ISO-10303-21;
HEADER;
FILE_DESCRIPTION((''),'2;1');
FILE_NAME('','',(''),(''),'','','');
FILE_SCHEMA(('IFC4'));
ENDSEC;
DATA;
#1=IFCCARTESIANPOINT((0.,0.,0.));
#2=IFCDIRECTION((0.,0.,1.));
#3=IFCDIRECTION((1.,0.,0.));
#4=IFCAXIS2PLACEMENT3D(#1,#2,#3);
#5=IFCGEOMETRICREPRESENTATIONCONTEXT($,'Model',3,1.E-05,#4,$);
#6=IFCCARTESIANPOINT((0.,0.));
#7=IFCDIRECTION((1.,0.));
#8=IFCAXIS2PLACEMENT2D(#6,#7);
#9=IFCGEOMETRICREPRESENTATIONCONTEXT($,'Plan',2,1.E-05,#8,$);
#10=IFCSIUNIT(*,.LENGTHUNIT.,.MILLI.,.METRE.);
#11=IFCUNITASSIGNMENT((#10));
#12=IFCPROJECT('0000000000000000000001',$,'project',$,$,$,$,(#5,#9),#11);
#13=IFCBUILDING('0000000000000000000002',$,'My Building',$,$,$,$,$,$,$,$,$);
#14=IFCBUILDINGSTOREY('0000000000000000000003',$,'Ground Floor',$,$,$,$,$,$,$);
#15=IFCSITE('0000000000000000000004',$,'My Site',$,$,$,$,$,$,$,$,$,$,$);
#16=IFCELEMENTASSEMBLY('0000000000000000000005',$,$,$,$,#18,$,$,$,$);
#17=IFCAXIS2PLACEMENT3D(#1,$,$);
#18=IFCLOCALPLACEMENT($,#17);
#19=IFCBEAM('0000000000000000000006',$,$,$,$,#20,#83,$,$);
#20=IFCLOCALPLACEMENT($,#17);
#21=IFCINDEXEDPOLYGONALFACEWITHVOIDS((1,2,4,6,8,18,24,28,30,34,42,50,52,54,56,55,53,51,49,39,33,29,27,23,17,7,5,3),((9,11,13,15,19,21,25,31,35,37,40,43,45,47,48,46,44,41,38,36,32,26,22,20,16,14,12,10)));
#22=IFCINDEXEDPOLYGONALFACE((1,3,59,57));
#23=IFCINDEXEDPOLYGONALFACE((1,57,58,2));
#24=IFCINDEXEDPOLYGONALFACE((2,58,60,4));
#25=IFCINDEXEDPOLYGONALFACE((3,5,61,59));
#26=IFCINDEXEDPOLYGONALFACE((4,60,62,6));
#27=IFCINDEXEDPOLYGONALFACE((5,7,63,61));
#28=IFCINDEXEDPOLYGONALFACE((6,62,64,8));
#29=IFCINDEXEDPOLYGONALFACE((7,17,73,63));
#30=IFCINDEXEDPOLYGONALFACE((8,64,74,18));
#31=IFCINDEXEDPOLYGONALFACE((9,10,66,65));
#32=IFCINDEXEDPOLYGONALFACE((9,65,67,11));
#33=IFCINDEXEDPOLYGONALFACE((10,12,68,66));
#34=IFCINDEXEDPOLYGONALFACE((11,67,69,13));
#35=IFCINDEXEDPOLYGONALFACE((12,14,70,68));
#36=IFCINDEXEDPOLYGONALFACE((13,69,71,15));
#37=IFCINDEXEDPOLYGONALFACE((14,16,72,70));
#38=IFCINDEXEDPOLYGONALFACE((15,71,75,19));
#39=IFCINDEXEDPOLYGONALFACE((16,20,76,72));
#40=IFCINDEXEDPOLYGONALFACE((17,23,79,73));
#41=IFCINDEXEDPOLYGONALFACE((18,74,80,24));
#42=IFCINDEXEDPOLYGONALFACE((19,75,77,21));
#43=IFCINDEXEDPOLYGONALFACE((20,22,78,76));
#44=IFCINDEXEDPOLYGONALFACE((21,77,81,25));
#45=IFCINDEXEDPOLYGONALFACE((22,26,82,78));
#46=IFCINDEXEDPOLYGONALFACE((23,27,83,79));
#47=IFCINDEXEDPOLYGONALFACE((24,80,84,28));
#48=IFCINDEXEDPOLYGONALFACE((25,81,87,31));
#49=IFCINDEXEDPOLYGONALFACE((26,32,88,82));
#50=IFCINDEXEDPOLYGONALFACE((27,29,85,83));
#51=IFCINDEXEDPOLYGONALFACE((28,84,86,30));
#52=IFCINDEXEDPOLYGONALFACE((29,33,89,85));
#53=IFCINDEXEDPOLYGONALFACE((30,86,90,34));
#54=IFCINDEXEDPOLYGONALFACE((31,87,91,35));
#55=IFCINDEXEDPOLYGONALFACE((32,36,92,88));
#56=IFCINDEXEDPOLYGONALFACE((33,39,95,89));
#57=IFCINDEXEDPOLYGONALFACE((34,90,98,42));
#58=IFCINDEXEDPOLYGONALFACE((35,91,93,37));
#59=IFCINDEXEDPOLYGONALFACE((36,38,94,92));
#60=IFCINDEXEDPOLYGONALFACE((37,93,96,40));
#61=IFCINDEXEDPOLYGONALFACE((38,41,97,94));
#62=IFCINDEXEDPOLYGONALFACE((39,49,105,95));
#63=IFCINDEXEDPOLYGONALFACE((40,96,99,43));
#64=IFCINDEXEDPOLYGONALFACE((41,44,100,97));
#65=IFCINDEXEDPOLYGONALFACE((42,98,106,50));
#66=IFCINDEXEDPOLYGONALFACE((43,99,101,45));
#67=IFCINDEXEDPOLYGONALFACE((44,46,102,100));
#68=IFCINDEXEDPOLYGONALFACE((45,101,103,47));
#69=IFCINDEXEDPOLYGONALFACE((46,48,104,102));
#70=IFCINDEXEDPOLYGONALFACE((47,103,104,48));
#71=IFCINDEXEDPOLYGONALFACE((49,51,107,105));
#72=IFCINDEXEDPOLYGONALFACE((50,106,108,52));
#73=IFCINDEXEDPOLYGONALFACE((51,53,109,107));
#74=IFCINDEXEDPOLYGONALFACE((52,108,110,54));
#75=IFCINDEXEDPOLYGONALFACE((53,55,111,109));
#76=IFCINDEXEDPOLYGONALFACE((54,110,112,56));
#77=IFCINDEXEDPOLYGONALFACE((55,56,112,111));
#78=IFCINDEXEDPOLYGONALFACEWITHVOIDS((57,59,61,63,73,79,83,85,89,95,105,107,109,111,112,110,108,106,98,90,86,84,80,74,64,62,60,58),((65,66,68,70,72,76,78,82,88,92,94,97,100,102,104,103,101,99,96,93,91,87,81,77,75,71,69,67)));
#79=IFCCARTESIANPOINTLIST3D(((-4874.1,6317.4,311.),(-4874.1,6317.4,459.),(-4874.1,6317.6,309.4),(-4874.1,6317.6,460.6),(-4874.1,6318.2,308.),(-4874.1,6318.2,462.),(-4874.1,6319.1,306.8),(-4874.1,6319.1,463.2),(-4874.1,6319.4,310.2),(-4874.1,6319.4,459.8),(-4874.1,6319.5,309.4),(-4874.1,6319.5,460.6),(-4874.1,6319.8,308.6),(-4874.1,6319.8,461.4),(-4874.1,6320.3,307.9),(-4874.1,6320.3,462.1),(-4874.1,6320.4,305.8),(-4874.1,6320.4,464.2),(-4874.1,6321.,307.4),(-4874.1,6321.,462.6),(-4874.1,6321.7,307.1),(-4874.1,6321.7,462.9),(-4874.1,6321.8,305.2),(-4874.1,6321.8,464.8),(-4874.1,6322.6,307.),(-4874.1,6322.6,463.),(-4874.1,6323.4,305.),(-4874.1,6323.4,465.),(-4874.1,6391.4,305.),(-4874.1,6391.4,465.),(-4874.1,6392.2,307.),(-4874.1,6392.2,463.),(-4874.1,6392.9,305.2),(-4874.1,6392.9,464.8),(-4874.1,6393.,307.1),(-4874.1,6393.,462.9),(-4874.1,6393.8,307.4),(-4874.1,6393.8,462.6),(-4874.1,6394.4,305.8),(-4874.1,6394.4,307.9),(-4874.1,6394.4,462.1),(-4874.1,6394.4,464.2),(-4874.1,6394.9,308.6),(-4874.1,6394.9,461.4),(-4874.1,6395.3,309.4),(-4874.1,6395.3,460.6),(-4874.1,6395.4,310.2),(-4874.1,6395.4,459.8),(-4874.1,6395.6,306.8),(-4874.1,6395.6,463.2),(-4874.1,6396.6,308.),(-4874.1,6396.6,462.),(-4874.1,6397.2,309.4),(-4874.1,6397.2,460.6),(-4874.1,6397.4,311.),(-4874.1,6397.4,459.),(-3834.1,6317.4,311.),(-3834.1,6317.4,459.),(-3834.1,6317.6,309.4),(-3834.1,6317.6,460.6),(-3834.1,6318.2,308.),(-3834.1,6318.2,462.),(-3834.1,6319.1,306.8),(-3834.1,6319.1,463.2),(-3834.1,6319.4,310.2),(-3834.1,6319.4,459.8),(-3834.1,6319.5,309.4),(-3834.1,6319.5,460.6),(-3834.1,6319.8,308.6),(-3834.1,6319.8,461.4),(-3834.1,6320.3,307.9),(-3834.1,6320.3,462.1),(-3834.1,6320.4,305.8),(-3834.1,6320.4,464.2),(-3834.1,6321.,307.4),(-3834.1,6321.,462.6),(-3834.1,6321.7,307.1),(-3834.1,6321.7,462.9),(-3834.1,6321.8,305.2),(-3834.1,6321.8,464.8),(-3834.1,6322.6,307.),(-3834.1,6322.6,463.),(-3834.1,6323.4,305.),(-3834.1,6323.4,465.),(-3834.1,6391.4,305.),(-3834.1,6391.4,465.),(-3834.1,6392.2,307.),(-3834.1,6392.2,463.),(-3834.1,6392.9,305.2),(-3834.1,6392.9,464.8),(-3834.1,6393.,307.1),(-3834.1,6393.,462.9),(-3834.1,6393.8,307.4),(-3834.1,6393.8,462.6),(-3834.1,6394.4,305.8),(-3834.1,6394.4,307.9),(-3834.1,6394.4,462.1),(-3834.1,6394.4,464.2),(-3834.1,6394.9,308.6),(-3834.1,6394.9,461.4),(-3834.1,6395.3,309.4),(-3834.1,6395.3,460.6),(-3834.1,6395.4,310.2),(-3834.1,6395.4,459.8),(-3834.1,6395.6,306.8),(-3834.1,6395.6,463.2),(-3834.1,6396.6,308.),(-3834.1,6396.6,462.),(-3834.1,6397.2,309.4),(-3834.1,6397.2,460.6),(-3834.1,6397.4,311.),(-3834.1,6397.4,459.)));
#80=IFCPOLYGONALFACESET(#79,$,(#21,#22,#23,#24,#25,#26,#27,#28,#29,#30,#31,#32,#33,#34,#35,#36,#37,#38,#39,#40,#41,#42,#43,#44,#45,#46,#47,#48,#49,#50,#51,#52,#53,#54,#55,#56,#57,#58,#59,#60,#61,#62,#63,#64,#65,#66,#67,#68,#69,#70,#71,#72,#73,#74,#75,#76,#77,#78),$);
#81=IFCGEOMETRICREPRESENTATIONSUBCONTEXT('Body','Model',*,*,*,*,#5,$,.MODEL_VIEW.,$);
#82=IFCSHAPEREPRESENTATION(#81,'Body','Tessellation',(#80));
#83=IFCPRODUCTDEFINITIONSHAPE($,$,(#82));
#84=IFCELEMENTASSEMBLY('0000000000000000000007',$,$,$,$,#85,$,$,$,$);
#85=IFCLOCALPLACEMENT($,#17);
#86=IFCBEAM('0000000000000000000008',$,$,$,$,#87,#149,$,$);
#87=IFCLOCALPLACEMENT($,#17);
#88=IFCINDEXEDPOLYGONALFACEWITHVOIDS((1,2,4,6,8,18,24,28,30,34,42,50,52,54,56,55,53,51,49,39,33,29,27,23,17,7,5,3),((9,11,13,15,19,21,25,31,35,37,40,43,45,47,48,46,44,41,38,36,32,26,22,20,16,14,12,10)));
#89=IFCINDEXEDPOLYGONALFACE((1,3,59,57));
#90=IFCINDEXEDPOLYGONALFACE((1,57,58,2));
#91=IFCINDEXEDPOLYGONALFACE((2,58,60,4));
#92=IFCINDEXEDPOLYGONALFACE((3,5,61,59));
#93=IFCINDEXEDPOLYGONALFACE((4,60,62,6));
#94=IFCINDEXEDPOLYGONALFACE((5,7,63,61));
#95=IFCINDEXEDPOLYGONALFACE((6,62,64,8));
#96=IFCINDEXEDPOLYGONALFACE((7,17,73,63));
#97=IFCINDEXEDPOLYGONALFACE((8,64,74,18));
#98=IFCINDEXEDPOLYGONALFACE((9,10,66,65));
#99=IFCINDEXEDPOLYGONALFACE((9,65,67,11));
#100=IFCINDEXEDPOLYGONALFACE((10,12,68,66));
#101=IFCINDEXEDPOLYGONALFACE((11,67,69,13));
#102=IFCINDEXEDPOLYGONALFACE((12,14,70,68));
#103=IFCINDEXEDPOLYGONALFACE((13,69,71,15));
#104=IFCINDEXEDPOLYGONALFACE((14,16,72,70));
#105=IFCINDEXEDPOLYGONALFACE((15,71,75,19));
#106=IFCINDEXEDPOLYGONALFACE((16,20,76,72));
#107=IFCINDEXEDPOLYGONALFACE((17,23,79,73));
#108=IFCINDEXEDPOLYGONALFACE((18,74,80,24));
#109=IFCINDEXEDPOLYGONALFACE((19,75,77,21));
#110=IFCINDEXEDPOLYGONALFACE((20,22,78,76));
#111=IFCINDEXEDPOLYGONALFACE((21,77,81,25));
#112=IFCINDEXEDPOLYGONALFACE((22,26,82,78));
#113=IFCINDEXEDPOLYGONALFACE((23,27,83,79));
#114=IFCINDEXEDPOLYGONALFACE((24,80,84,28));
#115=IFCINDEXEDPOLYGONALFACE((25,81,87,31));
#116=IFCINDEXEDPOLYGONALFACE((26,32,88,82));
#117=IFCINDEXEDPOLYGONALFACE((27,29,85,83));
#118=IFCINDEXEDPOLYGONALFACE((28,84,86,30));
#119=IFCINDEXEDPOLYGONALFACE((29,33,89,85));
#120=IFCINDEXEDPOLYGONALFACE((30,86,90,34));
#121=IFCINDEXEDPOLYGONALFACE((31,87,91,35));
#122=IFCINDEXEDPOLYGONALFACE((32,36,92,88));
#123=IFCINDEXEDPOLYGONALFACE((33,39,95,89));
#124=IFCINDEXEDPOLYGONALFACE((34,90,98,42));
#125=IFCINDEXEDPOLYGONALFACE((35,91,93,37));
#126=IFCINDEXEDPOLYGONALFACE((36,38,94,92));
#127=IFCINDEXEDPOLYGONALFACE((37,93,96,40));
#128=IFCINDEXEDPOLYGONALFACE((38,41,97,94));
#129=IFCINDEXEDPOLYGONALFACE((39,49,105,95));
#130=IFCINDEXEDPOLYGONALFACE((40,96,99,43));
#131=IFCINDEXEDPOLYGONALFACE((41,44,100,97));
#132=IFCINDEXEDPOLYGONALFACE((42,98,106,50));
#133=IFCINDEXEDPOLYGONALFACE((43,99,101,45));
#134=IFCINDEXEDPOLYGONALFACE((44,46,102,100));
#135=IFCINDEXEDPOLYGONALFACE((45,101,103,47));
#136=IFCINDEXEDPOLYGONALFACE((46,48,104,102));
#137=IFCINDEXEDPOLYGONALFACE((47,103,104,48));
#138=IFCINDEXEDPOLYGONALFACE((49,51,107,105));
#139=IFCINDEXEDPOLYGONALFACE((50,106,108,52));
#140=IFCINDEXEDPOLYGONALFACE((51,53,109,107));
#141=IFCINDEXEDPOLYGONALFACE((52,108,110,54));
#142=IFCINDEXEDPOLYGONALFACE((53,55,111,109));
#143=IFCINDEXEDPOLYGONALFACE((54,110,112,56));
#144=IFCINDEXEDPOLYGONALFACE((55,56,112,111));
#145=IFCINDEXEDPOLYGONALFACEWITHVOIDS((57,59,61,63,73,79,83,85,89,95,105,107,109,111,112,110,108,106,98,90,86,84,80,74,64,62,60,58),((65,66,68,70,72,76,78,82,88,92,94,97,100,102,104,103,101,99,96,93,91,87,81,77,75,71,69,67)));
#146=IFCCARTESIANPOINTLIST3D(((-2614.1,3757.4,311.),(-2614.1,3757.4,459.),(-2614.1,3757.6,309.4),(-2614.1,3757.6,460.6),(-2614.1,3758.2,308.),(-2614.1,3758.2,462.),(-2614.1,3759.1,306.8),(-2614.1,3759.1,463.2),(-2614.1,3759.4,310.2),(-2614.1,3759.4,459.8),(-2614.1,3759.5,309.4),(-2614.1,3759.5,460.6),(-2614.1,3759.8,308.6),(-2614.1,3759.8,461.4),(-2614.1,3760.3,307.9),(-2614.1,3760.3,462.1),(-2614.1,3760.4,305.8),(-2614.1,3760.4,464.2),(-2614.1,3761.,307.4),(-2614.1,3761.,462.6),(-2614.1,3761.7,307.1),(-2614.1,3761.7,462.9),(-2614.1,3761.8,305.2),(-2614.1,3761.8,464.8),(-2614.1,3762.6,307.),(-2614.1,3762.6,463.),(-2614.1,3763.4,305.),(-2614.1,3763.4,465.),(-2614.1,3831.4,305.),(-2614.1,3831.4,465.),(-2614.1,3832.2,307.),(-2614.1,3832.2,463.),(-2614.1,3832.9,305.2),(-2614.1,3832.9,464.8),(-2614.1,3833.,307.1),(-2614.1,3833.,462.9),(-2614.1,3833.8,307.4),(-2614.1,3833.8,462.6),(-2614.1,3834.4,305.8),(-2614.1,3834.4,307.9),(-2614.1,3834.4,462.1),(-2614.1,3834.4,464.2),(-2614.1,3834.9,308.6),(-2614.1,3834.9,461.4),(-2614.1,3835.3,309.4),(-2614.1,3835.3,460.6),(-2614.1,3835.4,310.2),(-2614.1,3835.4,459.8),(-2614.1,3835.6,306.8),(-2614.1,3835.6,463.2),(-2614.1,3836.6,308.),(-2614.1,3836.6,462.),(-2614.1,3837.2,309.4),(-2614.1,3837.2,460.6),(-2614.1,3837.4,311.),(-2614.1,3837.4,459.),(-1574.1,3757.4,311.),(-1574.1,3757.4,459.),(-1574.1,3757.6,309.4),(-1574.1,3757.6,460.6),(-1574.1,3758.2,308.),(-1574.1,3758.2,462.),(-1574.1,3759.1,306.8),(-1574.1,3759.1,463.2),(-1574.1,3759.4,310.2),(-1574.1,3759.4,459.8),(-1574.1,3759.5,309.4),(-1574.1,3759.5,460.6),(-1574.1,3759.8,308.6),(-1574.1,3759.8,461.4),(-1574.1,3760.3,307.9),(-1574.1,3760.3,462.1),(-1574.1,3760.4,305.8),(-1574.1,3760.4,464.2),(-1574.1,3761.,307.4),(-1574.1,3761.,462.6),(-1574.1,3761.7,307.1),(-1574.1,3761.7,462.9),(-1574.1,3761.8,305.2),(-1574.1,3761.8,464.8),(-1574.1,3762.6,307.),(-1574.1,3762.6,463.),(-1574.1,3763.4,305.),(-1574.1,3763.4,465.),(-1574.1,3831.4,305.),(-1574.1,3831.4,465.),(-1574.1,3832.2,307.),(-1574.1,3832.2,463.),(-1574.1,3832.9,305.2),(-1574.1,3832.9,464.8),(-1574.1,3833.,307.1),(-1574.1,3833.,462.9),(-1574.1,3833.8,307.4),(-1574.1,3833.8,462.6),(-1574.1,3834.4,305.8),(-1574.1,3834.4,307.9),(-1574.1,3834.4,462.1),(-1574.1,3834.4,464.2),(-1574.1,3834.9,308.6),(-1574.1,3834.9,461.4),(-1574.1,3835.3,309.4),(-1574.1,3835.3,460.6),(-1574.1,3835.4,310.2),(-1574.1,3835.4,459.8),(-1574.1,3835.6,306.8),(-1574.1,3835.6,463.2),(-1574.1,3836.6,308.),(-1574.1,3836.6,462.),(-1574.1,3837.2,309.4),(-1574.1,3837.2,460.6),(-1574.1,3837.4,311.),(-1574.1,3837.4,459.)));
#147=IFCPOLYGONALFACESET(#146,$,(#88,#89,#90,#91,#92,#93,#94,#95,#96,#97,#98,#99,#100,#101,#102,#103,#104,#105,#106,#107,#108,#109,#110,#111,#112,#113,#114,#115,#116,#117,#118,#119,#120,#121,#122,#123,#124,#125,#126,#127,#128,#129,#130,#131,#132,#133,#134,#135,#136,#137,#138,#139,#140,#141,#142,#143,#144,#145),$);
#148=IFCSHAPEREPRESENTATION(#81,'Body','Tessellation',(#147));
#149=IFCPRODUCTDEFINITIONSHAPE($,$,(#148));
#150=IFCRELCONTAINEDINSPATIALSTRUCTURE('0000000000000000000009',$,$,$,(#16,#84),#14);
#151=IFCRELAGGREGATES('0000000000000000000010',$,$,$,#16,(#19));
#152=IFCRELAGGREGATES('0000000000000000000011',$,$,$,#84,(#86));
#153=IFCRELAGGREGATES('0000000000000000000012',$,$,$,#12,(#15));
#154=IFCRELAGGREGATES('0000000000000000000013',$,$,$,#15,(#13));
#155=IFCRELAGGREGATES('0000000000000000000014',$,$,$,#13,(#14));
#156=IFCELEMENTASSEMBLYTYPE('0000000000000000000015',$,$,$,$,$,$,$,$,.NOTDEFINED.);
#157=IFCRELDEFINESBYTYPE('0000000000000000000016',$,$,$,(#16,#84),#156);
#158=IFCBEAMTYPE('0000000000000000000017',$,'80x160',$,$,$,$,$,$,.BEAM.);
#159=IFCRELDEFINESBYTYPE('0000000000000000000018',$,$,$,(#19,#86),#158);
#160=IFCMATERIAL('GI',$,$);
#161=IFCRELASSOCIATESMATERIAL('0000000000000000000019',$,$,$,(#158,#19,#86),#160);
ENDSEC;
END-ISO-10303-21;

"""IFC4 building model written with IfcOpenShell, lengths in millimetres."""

from ifc_helpers import new_model, si_unit, frame, origin_with_axes, origin_2d_with_axis, place, context, subcontext, project, spatial, hollow_rectangle, extrude, material, material_profile, profile_set, profile_usage, type_object, element, aggregate, save


model = new_model("IFC4")

# Units and contexts
model_context = context("Model", 3, precision=1e-05, world=origin_with_axes())
plan_context = context("Plan", 2, precision=1e-05, world=origin_2d_with_axis())
body_context = subcontext(model_context, "Body", "Model", "MODEL_VIEW")
ifc_project = project(units=[si_unit("LENGTHUNIT", "METRE", prefix="MILLI")], contexts=[model_context, plan_context])

# Site, building, storey
site = spatial("IfcSite", under=ifc_project, Name="My Site")
building = spatial("IfcBuilding", under=site, Name="My Building")
storey = spatial("IfcBuildingStorey", under=building, Name="Ground Floor")

# Shared definitions
ifc_material = material(Name="GI")

# Element assemblies, beams
element_assembly_type_1 = type_object("IfcElementAssemblyType", PredefinedType="NOTDEFINED")
ifc_material_profile_1 = material_profile(ifc_material, hollow_rectangle(XDim=80.0, YDim=160.0, WallThickness=2.0, InnerFilletRadius=3.2, OuterFilletRadius=6.0))
ifc_profile_set_1 = profile_set([ifc_material_profile_1], Name="80x160 GI Rectangular Hollow")
beam_type = type_object("IfcBeamType", Name="80x160", PredefinedType="BEAM", material=ifc_profile_set_1)
assembly_1_placement = place(None, frame((-4954.1, 6357.4, 385.0), z_axis=(1.0, 0.0, 0.0), x_axis=(0.0, 1.0, 0.0)))
assembly_1 = element("IfcElementAssembly", 1, at=assembly_1_placement, inside=storey, type_object=element_assembly_type_1)
ifc_profile_usage_1 = profile_usage(ifc_profile_set_1)
beam_1_placement = place(assembly_1_placement, frame((0.0, 0.0, 80.0), z_axis=(0.0, 0.0, 1.0), x_axis=(1.0, 0.0, 0.0)))
beam_1 = element("IfcBeam", 2, at=beam_1_placement, type_object=beam_type, material=ifc_profile_usage_1, context=body_context, shape_type="SweptSolid", body=[
    extrude(hollow_rectangle(XDim=80.0, YDim=160.0, WallThickness=2.0, InnerFilletRadius=3.2, OuterFilletRadius=6.0), origin_with_axes(), (0.0, 0.0, 1.0), 1040.0),
])
aggregate(assembly_1, [beam_1])
assembly_2_placement = place(None, frame((-2694.1, 3797.4, 385.0), z_axis=(1.0, 0.0, 0.0), x_axis=(0.0, 1.0, 0.0)))
assembly_2 = element("IfcElementAssembly", 3, at=assembly_2_placement, inside=storey, type_object=element_assembly_type_1)
ifc_profile_usage_2 = profile_usage(ifc_profile_set_1)
beam_2_placement = place(assembly_2_placement, frame((0.0, 0.0, 80.0), z_axis=(0.0, 0.0, 1.0), x_axis=(1.0, 0.0, 0.0)))
beam_2 = element("IfcBeam", 4, at=beam_2_placement, type_object=beam_type, material=ifc_profile_usage_2, context=body_context, shape_type="SweptSolid", body=[
    extrude(hollow_rectangle(XDim=80.0, YDim=160.0, WallThickness=2.0, InnerFilletRadius=3.2, OuterFilletRadius=6.0), origin_with_axes(), (0.0, 0.0, 1.0), 1040.0),
])
aggregate(assembly_2, [beam_2])

save(model, "model.ifc")
